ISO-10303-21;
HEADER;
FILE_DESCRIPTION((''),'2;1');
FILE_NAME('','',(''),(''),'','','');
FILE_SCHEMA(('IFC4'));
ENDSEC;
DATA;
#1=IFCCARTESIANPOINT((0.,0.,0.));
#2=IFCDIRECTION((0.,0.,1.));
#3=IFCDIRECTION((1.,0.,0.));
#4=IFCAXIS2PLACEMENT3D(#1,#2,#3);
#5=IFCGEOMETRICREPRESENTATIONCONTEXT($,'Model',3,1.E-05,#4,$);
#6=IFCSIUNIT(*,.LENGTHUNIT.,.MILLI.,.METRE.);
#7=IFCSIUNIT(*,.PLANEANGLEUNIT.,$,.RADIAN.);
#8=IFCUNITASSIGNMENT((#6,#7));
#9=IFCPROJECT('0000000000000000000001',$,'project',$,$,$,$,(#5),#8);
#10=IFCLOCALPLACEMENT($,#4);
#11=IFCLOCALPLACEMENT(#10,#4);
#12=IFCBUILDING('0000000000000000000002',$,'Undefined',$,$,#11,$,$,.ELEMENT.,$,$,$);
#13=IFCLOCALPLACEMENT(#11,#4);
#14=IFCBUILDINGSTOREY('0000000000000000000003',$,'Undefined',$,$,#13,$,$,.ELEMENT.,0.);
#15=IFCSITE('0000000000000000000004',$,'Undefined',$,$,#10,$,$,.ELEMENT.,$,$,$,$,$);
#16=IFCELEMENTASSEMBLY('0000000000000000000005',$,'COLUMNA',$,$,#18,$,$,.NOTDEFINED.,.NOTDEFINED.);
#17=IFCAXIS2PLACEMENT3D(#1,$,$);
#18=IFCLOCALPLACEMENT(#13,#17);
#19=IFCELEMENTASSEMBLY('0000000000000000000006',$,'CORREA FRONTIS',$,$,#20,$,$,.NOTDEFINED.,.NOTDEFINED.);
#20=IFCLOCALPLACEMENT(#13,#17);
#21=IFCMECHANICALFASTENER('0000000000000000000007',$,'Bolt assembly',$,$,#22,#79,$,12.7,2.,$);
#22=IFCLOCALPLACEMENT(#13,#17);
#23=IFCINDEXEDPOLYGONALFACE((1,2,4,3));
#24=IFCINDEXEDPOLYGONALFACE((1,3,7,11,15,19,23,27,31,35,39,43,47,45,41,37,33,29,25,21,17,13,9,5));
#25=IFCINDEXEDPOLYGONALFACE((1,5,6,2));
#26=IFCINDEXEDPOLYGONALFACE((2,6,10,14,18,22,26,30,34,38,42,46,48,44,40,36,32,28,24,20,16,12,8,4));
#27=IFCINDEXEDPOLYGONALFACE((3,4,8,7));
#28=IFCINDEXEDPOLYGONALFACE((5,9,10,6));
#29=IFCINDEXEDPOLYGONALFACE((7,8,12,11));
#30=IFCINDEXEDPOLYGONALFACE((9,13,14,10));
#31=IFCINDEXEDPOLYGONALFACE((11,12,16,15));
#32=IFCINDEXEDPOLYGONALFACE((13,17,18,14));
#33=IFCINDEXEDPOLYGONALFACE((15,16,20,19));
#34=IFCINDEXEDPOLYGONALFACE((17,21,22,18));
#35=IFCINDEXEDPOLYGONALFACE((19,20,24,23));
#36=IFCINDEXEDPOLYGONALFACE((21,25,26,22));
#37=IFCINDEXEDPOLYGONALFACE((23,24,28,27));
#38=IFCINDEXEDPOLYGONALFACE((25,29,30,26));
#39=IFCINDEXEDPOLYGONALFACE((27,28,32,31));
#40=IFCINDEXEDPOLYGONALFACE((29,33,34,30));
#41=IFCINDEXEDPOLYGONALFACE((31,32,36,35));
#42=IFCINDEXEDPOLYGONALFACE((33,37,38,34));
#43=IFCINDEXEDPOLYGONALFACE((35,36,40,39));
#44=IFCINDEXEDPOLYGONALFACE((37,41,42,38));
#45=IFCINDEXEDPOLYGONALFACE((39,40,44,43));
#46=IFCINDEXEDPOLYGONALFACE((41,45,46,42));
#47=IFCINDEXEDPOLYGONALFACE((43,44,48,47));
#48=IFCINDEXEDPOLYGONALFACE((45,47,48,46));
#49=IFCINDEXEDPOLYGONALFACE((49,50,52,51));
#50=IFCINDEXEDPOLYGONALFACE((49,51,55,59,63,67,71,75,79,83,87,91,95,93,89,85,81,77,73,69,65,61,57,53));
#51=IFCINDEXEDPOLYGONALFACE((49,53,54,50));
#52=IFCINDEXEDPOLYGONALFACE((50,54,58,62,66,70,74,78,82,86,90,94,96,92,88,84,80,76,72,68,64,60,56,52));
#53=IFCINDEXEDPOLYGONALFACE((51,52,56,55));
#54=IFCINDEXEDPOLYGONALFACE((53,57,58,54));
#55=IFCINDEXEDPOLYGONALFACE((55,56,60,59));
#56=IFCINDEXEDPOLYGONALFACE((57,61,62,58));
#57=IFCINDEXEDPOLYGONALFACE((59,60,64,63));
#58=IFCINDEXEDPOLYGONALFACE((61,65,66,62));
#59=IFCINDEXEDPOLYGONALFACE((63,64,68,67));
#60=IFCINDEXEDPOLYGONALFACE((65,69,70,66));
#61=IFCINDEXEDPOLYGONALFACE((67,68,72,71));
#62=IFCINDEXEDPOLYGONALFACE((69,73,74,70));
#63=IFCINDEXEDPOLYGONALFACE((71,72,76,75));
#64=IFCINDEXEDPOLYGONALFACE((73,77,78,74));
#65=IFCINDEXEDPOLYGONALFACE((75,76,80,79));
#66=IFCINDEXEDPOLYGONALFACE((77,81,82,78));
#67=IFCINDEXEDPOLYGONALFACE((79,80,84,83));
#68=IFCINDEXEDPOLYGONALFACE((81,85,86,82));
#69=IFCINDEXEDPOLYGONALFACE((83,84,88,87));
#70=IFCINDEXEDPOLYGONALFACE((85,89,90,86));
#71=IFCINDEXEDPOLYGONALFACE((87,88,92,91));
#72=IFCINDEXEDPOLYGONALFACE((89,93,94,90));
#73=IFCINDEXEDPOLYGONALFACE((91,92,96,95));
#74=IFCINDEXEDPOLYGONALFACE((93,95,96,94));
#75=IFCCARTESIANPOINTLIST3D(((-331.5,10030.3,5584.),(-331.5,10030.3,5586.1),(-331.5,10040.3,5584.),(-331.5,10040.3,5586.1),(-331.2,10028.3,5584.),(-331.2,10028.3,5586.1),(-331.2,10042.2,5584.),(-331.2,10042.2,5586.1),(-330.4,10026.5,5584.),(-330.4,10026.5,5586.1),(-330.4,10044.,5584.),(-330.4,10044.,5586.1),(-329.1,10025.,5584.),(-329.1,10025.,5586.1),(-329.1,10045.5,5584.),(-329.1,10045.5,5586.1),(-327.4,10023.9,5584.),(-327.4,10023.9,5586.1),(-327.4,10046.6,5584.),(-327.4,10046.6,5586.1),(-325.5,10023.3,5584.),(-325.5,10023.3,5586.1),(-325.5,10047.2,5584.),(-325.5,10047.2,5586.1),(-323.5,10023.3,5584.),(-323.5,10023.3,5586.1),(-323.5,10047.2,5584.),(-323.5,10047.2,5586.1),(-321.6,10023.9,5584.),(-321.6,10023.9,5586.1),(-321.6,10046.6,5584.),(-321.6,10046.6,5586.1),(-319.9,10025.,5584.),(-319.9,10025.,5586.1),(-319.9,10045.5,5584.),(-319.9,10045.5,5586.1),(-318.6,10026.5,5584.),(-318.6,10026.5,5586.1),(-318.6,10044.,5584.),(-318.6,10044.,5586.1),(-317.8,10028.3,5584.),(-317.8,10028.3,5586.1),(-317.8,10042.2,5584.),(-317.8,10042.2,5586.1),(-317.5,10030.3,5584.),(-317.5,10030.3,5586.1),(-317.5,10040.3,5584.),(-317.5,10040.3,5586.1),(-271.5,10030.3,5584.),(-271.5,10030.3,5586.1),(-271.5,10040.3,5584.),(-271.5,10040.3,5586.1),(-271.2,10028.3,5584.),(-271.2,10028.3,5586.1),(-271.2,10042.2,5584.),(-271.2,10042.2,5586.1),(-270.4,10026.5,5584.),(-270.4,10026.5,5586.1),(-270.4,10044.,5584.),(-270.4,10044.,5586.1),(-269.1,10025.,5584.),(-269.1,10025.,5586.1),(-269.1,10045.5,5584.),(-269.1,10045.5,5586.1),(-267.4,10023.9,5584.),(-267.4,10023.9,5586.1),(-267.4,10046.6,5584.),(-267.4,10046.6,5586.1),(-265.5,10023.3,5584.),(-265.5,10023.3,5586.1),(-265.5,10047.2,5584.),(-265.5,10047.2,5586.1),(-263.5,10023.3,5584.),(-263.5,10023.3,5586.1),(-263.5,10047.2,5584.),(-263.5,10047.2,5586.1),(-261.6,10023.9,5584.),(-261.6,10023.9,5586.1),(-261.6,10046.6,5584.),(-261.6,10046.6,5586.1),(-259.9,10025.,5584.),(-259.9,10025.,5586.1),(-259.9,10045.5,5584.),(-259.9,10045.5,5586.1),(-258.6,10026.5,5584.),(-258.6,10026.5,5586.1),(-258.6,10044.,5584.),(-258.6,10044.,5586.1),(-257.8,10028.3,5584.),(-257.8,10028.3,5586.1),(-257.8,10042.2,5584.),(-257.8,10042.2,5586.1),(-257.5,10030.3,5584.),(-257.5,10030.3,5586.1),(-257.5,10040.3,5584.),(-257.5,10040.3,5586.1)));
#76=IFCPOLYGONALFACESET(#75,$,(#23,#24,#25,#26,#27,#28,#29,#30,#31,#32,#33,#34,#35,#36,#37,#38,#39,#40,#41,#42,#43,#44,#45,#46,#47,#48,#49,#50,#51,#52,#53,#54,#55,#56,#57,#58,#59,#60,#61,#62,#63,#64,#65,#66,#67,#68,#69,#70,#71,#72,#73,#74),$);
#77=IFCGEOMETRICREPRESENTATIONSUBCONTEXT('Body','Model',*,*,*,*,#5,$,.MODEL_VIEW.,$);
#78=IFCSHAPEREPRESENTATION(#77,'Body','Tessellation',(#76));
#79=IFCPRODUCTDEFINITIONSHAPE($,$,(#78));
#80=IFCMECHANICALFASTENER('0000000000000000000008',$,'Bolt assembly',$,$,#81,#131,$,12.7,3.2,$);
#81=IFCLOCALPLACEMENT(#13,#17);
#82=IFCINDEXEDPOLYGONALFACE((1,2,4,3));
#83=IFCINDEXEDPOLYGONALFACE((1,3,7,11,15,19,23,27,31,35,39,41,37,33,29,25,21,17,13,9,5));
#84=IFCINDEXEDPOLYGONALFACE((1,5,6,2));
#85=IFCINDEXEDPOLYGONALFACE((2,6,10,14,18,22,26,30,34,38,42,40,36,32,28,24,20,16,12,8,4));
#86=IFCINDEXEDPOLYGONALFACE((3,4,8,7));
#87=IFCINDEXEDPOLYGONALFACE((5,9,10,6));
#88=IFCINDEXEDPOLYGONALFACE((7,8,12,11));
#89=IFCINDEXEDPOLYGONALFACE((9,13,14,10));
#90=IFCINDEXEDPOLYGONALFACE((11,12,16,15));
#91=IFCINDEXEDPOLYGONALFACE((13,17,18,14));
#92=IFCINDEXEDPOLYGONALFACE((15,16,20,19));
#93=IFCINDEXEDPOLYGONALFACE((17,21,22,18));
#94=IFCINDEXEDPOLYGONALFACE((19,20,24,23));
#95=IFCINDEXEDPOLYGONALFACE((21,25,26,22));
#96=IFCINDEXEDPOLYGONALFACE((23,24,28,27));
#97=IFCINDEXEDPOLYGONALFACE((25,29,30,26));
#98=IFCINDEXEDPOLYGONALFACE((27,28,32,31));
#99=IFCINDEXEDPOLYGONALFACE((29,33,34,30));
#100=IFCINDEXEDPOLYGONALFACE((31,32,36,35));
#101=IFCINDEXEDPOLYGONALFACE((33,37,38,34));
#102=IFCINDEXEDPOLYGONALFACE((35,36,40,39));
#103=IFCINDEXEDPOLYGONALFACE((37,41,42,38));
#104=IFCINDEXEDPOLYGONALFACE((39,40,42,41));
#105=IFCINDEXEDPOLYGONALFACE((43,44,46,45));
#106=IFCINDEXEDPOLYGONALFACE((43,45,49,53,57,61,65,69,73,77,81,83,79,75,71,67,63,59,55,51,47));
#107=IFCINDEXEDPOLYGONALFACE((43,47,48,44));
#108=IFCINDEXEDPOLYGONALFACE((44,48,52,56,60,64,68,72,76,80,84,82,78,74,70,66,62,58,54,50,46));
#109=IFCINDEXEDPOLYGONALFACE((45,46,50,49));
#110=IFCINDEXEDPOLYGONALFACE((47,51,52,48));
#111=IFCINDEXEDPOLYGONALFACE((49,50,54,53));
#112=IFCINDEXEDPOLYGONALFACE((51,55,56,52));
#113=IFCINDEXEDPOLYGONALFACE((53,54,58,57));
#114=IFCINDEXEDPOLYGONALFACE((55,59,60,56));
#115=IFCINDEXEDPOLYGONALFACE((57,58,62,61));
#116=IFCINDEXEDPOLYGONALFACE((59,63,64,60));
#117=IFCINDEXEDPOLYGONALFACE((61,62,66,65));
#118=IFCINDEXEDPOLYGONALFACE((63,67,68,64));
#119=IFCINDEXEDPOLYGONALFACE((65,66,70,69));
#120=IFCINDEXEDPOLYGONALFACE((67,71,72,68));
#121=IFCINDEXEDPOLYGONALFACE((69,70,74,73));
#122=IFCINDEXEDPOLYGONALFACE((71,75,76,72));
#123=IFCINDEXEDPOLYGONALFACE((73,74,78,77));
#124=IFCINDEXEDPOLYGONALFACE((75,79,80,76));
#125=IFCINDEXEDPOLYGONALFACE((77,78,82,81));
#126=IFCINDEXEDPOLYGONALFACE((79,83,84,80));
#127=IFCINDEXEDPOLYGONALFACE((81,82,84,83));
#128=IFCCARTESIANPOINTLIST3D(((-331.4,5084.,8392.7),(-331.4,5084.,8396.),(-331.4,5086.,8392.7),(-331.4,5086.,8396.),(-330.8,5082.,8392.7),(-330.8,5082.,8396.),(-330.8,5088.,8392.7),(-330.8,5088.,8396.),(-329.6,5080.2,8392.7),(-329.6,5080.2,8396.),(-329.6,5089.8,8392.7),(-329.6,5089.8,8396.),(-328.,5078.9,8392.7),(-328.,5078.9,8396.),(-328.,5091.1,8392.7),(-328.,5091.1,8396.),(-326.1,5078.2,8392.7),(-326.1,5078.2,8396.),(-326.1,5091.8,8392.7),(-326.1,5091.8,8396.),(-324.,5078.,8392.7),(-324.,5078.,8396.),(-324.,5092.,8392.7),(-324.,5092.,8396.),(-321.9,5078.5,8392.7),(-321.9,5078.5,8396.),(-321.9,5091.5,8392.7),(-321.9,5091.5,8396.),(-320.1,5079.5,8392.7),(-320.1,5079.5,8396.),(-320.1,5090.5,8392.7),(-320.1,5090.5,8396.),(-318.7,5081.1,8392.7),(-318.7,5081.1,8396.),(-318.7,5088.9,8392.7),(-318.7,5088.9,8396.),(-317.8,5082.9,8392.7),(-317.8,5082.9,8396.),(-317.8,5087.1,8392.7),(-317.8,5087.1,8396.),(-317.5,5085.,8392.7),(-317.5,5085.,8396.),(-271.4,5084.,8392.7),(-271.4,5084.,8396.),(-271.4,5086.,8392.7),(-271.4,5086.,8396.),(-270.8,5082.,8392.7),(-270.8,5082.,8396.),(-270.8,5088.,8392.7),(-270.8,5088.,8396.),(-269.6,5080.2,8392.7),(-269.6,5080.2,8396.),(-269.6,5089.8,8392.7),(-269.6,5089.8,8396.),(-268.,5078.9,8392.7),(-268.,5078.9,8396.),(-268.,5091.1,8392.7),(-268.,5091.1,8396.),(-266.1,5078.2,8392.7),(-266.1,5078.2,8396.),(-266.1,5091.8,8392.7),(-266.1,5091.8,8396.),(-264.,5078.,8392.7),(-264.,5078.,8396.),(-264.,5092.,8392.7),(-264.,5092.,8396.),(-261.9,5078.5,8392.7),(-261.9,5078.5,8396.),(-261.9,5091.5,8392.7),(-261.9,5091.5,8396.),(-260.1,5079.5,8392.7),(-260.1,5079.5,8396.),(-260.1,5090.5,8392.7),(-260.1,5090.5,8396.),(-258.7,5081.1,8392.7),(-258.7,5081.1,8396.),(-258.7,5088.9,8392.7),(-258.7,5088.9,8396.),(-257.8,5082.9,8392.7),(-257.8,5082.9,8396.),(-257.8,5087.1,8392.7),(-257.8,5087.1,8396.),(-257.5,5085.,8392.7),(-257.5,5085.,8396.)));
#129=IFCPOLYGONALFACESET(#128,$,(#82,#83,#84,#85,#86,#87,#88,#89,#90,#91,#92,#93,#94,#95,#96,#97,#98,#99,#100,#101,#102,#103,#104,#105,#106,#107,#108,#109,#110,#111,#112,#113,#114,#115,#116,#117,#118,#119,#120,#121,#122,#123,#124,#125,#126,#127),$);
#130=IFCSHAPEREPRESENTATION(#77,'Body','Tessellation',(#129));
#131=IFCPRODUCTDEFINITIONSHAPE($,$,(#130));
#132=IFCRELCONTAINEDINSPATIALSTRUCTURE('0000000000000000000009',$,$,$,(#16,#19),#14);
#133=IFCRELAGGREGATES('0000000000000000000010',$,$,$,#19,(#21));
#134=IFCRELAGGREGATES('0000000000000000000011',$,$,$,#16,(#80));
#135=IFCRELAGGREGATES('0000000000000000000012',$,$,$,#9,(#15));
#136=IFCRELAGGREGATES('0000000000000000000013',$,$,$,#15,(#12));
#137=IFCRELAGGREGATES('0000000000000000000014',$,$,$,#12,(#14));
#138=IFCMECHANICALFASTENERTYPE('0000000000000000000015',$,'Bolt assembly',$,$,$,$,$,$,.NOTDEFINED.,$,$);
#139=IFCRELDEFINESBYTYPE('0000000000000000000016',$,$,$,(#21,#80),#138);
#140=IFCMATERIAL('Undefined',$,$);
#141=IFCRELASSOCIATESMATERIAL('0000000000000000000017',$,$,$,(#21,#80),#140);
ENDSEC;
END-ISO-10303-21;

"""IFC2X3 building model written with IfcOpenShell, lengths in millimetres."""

from ifc_helpers import new_model, si_unit, frame, frame_2d, origin_with_axes, origin_2d_with_axis, place, context, subcontext, project, spatial, polyline, circle_curve, parameter, trimmed, segment, composite_curve, circle, outline, extrude, source, transform, mapped, material, type_object, element, aggregate, save


model = new_model("IFC2X3")

# Units and contexts
model_context = context("Model", 3, precision=1e-05, world=origin_with_axes())
body_context = subcontext(model_context, "Body", "Model", "MODEL_VIEW")
ifc_project = project(units=[si_unit("LENGTHUNIT", "METRE", prefix="MILLI"), si_unit("PLANEANGLEUNIT", "RADIAN")], contexts=[model_context])

# Site, building, storey
site_placement = place(None, origin_with_axes())
site = spatial("IfcSite", under=ifc_project, at=site_placement, Name="Undefined", CompositionType="ELEMENT")
building_placement = place(site_placement, origin_with_axes())
building = spatial("IfcBuilding", under=site, at=building_placement, Name="Undefined", CompositionType="ELEMENT")
storey_placement = place(building_placement, origin_with_axes())
storey = spatial("IfcBuildingStorey", under=building, at=storey_placement, Name="Undefined", CompositionType="ELEMENT", Elevation=0.0)

# Element assembly
assembly_1_placement = place(storey_placement, origin_with_axes())
assembly_1 = element("IfcElementAssembly", 1, at=assembly_1_placement, inside=storey, Name="COLUMNA", AssemblyPlace="NOTDEFINED", PredefinedType="NOTDEFINED")

# Shared definitions
ifc_material_1 = material(Name="Undefined")
mechanical_fastener_type = type_object("IfcMechanicalFastenerType", Name="Bolt assembly")

# Element assembly, mechanical fastener
assembly_2_placement = place(storey_placement, origin_with_axes())
assembly_2 = element("IfcElementAssembly", 2, at=assembly_2_placement, inside=storey, Name="CORREA FRONTIS", AssemblyPlace="NOTDEFINED", PredefinedType="NOTDEFINED")
shared_shape_1 = source(origin_with_axes(), body_context, "Body", "SweptSolid", [
    extrude(outline(composite_curve([segment(polyline([(7.0, 5.0), (7.0, -5.0)]), True, "CONTINUOUS"), segment(trimmed(circle_curve(frame_2d((0.0, -5.0), x_axis=(1.0, 0.0)), 7.0), [parameter(0.0)], [parameter(3.141593)], False, "PARAMETER"), True, "CONTINUOUS"), segment(polyline([(-7.0, -5.0), (-7.0, 5.0)]), True, "CONTINUOUS"), segment(trimmed(circle_curve(frame_2d((0.0, 5.0), x_axis=(-1.0, 0.0)), 7.0), [parameter(0.0)], [parameter(3.141593)], False, "PARAMETER"), True, "DISCONTINUOUS")], self_intersect=False)), frame((0.0, 0.0, 0.0), z_axis=(0.0, 1.0, 0.0), x_axis=(1.0, 0.0, 0.0)), (0.0, 0.0, 1.0), 2.1),
])
mechanical_fastener_1_placement = place(assembly_2_placement, frame((-324.5, 10035.3, 5586.1), z_axis=(-0.000002, 1.0, 0.0), x_axis=(1.0, 0.000002, 0.000004)))
mechanical_fastener_1 = element("IfcMechanicalFastener", 3, at=mechanical_fastener_1_placement, type_object=mechanical_fastener_type, material=ifc_material_1, Name="Bolt assembly", NominalDiameter=12.7, NominalLength=2.0, context=body_context, shape_type="MappedRepresentation", body=[
    mapped(shared_shape_1, transform((0.0, 0.0, 0.0))),
    mapped(shared_shape_1, transform((60.0, 0.0, 0.0))),
])

aggregate(assembly_2, [mechanical_fastener_1])

# Mechanical fastener
shared_shape_2 = source(origin_with_axes(), body_context, "Body", "SweptSolid", [
    extrude(circle(Radius=7.0, at=origin_2d_with_axis()), frame((0.0, -3.2, 0.0), z_axis=(0.0, 1.0, 0.0), x_axis=(1.0, 0.0, 0.0)), (0.0, 0.0, 1.0), 3.3),
])
mechanical_fastener_2_placement = place(assembly_1_placement, frame((-324.5, 5085.0, 8392.8), z_axis=(0.000001, 1.0, 0.0), x_axis=(1.0, -0.000001, 0.000004)))
mechanical_fastener_2 = element("IfcMechanicalFastener", 4, at=mechanical_fastener_2_placement, type_object=mechanical_fastener_type, material=ifc_material_1, Name="Bolt assembly", NominalDiameter=12.7, NominalLength=3.2, context=body_context, shape_type="MappedRepresentation", body=[
    mapped(shared_shape_2, transform((0.0, 0.0, 0.0))),
    mapped(shared_shape_2, transform((60.0, 0.0, 0.0))),
])
aggregate(assembly_1, [mechanical_fastener_2])

save(model, "model.ifc")
